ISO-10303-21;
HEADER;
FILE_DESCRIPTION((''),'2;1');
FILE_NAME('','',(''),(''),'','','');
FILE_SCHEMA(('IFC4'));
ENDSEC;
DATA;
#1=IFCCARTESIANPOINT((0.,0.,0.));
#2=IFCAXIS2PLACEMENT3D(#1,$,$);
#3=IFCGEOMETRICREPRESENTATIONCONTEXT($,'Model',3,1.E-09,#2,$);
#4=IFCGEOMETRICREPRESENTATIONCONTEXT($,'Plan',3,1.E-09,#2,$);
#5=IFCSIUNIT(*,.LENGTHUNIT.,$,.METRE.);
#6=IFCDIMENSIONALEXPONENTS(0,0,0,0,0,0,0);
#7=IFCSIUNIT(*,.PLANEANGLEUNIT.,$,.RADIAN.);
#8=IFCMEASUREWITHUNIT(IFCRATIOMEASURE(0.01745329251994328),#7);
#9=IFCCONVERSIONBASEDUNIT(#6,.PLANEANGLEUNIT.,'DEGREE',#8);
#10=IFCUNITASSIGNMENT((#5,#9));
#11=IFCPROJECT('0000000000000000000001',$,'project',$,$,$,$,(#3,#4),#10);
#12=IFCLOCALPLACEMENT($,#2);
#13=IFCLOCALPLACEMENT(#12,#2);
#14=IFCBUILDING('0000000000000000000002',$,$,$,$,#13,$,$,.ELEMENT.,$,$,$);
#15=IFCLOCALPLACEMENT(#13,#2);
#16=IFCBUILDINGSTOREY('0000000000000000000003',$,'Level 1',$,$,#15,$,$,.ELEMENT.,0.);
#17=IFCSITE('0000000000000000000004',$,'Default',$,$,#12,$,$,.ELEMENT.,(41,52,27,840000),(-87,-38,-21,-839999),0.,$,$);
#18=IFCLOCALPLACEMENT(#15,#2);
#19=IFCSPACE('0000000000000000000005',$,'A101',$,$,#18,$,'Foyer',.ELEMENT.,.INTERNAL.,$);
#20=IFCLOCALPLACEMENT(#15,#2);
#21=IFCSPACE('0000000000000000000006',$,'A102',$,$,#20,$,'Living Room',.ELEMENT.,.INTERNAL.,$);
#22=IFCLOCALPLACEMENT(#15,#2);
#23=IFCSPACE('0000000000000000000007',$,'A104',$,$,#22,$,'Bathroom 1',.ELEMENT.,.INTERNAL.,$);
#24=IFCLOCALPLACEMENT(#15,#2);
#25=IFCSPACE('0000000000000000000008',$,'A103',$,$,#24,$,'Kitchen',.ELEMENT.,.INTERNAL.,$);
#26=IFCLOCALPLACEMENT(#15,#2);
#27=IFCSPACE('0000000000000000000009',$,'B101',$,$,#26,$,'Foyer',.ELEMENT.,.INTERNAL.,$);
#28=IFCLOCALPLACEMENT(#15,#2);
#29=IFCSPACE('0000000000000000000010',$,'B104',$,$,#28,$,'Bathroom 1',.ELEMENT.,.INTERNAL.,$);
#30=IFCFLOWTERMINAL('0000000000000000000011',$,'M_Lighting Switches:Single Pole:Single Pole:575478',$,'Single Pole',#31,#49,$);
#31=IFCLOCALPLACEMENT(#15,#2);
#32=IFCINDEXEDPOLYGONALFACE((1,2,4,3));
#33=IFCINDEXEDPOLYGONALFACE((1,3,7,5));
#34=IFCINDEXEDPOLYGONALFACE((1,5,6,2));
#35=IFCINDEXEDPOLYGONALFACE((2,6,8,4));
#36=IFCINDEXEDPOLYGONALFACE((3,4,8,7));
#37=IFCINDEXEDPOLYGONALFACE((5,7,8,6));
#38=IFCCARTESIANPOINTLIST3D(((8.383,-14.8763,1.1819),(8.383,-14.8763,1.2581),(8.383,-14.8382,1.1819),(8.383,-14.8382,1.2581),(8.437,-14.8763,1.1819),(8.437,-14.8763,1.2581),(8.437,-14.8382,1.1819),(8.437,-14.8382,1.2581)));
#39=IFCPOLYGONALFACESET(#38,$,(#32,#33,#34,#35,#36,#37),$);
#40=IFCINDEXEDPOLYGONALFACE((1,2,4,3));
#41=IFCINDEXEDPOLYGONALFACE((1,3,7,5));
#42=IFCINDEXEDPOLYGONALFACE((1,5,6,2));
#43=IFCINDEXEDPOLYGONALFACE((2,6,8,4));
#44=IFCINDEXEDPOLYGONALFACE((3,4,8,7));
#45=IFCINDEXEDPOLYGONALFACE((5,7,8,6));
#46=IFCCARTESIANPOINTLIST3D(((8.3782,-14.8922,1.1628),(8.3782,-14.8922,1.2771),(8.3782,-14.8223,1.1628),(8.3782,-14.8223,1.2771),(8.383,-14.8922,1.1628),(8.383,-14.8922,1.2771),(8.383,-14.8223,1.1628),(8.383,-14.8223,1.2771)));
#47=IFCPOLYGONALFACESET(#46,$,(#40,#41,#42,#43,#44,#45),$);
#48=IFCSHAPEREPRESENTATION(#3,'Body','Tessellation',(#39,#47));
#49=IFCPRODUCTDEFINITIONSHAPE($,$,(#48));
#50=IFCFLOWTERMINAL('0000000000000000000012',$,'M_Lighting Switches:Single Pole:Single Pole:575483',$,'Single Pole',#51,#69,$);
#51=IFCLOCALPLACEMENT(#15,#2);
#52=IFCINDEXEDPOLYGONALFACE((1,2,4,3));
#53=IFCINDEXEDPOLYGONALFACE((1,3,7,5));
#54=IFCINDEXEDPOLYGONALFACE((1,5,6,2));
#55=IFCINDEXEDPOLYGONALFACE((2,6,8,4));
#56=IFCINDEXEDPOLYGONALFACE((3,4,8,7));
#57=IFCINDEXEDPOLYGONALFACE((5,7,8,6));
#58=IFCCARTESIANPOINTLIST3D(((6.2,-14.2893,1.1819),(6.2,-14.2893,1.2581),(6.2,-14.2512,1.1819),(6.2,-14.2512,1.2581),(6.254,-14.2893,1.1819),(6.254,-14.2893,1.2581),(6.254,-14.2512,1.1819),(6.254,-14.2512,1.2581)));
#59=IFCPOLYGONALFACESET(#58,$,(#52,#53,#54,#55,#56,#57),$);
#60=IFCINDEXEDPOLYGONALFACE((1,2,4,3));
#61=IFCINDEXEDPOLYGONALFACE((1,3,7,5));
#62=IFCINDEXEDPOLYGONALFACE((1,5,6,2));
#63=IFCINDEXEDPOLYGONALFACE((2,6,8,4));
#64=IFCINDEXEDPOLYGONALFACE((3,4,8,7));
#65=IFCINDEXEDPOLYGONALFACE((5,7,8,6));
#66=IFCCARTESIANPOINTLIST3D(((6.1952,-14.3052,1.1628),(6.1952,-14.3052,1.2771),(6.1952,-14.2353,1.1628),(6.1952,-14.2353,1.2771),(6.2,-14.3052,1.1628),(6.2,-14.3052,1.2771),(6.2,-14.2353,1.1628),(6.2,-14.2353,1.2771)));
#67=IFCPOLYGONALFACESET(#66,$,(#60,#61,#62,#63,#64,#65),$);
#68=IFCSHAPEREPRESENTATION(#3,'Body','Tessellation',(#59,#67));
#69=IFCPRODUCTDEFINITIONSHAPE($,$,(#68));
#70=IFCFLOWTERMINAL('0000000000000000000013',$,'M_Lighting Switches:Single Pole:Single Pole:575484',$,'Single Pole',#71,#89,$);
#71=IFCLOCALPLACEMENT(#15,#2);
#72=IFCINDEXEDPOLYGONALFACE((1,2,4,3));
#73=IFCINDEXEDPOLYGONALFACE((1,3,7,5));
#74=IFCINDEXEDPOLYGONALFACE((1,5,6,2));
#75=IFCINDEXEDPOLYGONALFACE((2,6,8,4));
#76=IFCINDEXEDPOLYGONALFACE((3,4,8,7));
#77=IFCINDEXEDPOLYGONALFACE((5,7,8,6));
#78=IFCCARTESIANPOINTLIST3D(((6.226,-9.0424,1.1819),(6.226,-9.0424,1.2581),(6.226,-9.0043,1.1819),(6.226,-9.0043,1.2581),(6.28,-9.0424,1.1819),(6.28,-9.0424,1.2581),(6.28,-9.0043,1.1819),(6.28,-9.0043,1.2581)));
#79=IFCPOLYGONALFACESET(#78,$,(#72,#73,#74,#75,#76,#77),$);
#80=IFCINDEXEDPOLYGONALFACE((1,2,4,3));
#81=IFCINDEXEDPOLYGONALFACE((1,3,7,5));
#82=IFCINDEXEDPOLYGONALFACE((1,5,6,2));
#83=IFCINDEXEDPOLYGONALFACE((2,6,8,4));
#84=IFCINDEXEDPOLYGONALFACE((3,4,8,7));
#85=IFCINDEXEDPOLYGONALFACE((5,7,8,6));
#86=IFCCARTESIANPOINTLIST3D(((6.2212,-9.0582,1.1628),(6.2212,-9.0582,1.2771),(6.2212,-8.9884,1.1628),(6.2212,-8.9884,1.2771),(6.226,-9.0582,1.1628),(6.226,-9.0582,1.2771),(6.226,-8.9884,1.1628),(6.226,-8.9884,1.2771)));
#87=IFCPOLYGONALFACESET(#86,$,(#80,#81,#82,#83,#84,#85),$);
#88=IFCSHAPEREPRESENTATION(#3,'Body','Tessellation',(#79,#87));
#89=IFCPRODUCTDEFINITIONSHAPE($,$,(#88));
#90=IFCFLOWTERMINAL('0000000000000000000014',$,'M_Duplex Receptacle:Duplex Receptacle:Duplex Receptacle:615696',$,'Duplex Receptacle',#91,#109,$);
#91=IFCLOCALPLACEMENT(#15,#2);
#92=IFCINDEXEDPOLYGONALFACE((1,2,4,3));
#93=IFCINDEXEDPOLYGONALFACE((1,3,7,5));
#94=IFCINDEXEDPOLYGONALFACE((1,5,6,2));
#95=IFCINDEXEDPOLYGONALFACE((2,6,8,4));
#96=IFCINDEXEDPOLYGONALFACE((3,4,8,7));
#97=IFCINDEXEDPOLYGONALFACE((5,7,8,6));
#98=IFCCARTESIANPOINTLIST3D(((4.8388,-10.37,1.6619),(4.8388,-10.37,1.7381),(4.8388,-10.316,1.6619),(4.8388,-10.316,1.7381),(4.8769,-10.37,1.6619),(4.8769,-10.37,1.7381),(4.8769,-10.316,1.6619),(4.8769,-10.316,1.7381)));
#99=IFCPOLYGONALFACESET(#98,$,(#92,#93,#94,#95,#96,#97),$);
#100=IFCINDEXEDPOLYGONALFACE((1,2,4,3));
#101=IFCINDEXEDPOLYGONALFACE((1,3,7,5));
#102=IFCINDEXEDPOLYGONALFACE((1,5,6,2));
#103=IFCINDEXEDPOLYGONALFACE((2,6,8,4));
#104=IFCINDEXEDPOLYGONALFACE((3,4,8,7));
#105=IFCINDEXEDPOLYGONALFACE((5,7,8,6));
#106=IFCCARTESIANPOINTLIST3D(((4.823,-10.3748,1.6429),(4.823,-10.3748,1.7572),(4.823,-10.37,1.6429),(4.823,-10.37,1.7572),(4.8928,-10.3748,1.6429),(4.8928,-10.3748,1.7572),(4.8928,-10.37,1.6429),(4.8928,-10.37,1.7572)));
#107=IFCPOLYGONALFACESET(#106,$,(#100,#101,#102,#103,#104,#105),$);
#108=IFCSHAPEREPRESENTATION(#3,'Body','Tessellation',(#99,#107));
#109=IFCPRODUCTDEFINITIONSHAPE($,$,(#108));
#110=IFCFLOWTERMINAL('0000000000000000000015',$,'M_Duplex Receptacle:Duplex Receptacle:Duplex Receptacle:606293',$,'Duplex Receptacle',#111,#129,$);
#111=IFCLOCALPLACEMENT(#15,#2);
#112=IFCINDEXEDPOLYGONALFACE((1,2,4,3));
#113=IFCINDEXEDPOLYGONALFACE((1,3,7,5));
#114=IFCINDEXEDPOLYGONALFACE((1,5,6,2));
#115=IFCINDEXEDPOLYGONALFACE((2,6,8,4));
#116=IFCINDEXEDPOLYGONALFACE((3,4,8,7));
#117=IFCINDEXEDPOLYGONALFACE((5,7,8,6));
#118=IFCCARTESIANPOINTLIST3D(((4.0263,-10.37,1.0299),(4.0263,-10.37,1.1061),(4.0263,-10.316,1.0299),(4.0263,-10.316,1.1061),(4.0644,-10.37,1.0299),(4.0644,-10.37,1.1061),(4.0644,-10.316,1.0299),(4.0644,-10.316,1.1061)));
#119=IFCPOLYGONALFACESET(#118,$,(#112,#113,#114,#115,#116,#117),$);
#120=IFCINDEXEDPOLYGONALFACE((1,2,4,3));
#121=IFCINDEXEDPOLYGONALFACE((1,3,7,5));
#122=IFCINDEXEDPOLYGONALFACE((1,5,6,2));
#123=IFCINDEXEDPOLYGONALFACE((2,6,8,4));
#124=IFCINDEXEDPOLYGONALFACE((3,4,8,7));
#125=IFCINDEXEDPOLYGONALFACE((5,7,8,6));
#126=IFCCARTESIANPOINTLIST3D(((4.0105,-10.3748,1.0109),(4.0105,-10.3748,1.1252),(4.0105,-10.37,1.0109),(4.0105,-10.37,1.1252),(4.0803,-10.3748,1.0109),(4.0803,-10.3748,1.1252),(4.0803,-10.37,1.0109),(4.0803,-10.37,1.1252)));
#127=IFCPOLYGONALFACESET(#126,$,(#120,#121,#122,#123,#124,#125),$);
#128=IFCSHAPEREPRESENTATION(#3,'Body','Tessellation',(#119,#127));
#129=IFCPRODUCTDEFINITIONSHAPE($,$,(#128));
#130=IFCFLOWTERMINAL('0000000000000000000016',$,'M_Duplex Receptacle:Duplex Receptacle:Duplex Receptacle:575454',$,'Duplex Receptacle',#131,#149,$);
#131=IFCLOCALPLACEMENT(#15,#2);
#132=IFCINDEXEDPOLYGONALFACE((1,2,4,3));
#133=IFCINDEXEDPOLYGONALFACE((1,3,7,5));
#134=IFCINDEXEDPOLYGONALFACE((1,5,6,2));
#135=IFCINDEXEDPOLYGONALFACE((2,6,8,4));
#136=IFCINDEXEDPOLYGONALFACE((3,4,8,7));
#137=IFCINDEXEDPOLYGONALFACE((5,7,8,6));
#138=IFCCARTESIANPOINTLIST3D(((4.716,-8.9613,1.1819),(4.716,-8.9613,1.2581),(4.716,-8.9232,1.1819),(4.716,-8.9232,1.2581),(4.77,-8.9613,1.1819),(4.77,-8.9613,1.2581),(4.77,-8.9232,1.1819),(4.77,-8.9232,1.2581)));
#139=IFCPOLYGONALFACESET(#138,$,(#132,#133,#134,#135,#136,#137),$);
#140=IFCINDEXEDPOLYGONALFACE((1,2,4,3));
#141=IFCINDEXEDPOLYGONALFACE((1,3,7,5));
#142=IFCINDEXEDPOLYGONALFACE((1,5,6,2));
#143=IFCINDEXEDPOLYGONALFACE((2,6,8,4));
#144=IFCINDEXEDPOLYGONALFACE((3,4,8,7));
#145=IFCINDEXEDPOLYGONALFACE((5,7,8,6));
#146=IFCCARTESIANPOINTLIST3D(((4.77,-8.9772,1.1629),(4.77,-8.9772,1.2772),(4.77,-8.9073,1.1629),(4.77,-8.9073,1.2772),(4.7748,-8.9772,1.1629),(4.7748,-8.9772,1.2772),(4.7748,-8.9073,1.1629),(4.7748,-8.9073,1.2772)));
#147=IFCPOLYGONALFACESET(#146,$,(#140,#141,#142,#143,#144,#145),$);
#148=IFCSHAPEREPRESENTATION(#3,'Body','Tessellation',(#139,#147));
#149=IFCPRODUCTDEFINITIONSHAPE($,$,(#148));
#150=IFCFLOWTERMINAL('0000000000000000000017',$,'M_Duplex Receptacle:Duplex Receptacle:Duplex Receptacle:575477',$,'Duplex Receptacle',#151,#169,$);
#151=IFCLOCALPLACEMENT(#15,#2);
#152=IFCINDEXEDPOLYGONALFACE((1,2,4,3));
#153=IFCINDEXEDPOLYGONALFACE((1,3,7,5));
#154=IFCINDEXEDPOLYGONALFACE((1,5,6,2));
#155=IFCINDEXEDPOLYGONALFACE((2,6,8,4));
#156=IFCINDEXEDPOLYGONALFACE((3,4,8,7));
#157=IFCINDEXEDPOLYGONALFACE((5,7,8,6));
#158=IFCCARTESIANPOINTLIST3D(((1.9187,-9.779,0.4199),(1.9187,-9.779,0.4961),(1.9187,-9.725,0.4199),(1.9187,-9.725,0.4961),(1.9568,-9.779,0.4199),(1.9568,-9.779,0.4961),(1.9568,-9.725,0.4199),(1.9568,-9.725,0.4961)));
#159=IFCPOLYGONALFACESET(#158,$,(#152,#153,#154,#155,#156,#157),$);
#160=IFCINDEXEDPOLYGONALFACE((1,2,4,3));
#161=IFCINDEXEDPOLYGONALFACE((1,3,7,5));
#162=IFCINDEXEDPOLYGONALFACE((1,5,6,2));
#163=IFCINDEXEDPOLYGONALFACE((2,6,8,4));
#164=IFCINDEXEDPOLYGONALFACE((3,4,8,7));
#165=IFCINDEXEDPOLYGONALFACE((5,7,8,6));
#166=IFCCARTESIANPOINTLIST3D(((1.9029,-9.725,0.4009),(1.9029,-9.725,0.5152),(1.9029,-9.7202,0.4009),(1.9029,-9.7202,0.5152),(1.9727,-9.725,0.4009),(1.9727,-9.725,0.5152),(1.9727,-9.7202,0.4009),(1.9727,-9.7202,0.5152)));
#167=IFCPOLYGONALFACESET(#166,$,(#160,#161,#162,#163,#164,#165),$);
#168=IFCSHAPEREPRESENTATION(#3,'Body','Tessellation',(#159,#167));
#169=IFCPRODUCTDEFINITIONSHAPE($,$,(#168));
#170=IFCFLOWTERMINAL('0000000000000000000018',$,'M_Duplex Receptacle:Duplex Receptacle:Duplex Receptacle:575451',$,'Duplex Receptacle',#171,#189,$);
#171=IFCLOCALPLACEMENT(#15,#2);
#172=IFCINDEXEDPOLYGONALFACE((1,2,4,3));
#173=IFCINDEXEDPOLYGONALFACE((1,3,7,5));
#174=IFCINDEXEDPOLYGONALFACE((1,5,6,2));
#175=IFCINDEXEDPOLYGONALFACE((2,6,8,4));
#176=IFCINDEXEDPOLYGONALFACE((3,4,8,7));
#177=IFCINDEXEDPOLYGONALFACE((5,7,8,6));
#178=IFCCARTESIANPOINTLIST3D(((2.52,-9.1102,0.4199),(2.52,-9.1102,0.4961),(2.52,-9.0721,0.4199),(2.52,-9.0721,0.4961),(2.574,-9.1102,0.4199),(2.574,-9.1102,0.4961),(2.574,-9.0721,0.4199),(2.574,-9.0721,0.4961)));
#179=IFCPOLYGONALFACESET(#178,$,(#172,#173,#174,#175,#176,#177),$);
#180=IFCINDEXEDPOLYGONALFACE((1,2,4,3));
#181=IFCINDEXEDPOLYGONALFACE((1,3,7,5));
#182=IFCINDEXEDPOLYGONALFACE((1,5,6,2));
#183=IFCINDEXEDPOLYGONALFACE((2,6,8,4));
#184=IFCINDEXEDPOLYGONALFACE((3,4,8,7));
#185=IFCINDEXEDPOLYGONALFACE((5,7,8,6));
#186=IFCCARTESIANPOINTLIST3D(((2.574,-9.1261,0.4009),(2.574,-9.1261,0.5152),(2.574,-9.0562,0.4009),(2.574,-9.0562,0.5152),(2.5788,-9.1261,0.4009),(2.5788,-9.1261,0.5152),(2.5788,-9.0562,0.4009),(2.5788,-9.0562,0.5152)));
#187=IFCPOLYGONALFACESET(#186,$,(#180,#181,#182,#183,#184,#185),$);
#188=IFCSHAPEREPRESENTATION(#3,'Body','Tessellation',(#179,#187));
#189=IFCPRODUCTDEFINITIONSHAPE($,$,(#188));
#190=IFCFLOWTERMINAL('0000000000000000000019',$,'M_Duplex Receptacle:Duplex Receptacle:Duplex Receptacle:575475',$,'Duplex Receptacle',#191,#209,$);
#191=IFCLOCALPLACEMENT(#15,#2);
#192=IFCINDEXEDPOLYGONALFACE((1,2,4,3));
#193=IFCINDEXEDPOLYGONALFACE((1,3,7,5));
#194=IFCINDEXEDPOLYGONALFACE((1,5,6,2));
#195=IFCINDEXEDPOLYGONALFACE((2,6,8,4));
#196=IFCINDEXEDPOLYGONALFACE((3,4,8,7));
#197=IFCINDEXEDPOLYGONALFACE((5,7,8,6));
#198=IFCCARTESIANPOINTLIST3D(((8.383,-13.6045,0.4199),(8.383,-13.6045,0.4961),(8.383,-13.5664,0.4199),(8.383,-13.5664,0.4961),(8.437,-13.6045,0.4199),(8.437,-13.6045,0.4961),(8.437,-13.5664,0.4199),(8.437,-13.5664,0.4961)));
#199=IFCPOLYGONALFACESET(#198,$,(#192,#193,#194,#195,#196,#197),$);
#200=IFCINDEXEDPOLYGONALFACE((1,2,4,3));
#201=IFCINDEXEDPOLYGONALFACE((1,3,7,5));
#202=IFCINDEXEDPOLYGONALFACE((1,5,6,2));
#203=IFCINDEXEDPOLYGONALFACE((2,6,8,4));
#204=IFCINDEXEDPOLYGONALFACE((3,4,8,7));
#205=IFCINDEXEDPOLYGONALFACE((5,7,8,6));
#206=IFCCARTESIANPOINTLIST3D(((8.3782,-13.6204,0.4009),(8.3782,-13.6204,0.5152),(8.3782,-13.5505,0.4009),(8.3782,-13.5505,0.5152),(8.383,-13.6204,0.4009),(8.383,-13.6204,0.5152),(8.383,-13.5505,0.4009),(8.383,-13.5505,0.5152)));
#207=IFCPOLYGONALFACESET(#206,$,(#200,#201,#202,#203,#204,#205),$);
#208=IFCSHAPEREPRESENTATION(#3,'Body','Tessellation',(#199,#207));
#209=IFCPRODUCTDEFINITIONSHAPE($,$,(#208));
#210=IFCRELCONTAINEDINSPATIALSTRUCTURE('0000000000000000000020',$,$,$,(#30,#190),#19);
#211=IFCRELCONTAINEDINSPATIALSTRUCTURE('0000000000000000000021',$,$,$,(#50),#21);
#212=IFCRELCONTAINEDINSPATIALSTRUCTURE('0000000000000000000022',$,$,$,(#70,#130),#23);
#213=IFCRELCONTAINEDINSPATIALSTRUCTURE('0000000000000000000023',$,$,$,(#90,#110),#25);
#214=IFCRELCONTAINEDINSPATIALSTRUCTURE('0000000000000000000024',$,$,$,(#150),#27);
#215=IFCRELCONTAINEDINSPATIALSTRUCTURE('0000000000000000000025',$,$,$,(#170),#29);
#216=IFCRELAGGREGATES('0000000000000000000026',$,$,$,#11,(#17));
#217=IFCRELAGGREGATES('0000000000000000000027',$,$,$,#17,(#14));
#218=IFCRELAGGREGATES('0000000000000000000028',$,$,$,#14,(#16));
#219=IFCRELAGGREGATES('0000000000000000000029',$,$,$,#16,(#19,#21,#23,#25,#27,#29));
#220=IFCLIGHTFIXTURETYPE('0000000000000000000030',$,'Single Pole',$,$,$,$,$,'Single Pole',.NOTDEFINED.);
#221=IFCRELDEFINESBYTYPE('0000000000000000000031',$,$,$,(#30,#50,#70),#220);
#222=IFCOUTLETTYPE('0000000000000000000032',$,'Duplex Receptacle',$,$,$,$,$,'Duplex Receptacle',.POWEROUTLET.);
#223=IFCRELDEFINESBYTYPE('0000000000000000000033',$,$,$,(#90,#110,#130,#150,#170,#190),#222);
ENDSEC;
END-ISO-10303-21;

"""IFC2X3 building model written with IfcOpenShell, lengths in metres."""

from ifc_helpers import new_model, entity, si_unit, converted_unit, frame, origin, origin_2d_with_axis, place, context, project, spatial, rectangle, extrude, source, transform, mapped, type_object, type_shapes, element, save


model = new_model("IFC2X3")

# Units and contexts
model_context = context("Model", 3, precision=1e-09, world=origin())
plan_context = context("Plan", 3, precision=1e-09, world=origin())
ifc_project = project(units=[si_unit("LENGTHUNIT", "METRE"), converted_unit("PLANEANGLEUNIT", "DEGREE", entity("IfcRatioMeasure", 0.01745329251994328), si_unit("PLANEANGLEUNIT", "RADIAN"), dimensions=[0, 0, 0, 0, 0, 0, 0])], contexts=[model_context, plan_context])

# Site, building, storey, space
site_placement = place(None, origin())
site = spatial("IfcSite", under=ifc_project, at=site_placement, Name="Default", CompositionType="ELEMENT", RefLatitude=(41, 52, 27, 840000), RefLongitude=(-87, -38, -21, -839999), RefElevation=0.0)
building_placement = place(site_placement, origin())
building = spatial("IfcBuilding", under=site, at=building_placement, CompositionType="ELEMENT")
storey_placement = place(building_placement, origin())
storey = spatial("IfcBuildingStorey", under=building, at=storey_placement, Name="Level 1", CompositionType="ELEMENT", Elevation=0.0)
space_1_placement = place(storey_placement, origin())
space_1 = spatial("IfcSpace", under=storey, at=space_1_placement, Name="A101", LongName="Foyer", CompositionType="ELEMENT", InteriorOrExteriorSpace="INTERNAL")

# Flow terminal
light_fixture_type = type_object("IfcLightFixtureType", Name="Single Pole", ElementType="Single Pole", PredefinedType="NOTDEFINED")
shared_shape_1 = source(origin(), model_context, "Body", "SweptSolid", [
    extrude(rectangle(XDim=0.0381, YDim=0.0762, at=origin_2d_with_axis()), frame((0.0, 0.0, -0.054), z_axis=(0.0, 0.0, 1.0), x_axis=(-1.0, 0.0, 0.0)), (0.0, 0.0, 1.0), 0.054),
    extrude(rectangle(XDim=0.0698, YDim=0.1143, at=origin_2d_with_axis()), frame((0.0, 0.0, 0.0), z_axis=(0.0, 0.0, 1.0), x_axis=(-1.0, 0.0, 0.0)), (0.0, 0.0, 1.0), 0.0048),
])
type_shapes(light_fixture_type, [shared_shape_1])
flow_terminal_1_placement = place(space_1_placement, frame((8.383, -14.8573, 1.22), z_axis=(-1.0, 0.0, 0.0), x_axis=(0.0, -1.0, 0.0)))
element("IfcFlowTerminal", 1, at=flow_terminal_1_placement, inside=space_1, type_object=light_fixture_type, Name="M_Lighting Switches:Single Pole:Single Pole:575478", ObjectType="Single Pole", context=model_context, shape_type="MappedRepresentation", body=[
    mapped(shared_shape_1, transform((0.0, 0.0, 0.0), scale=1.0)),
])

# Shared definitions
space_2_placement = place(storey_placement, origin())
space_2 = spatial("IfcSpace", under=storey, at=space_2_placement, Name="A102", LongName="Living Room", CompositionType="ELEMENT", InteriorOrExteriorSpace="INTERNAL")

# Flow terminal
flow_terminal_2_placement = place(space_2_placement, frame((6.2, -14.2702, 1.22), z_axis=(-1.0, 0.0, 0.0), x_axis=(0.0, -1.0, 0.0)))
element("IfcFlowTerminal", 2, at=flow_terminal_2_placement, inside=space_2, type_object=light_fixture_type, Name="M_Lighting Switches:Single Pole:Single Pole:575483", ObjectType="Single Pole", context=model_context, shape_type="MappedRepresentation", body=[
    mapped(shared_shape_1, transform((0.0, 0.0, 0.0), scale=1.0)),
])

# Shared definitions
space_3_placement = place(storey_placement, origin())
space_3 = spatial("IfcSpace", under=storey, at=space_3_placement, Name="A104", LongName="Bathroom 1", CompositionType="ELEMENT", InteriorOrExteriorSpace="INTERNAL")

# Flow terminal
flow_terminal_3_placement = place(space_3_placement, frame((6.226, -9.0233, 1.22), z_axis=(-1.0, 0.0, 0.0), x_axis=(0.0, -1.0, 0.0)))
element("IfcFlowTerminal", 3, at=flow_terminal_3_placement, inside=space_3, type_object=light_fixture_type, Name="M_Lighting Switches:Single Pole:Single Pole:575484", ObjectType="Single Pole", context=model_context, shape_type="MappedRepresentation", body=[
    mapped(shared_shape_1, transform((0.0, 0.0, 0.0), scale=1.0)),
])

# Shared definitions
space_4_placement = place(storey_placement, origin())
space_4 = spatial("IfcSpace", under=storey, at=space_4_placement, Name="A103", LongName="Kitchen", CompositionType="ELEMENT", InteriorOrExteriorSpace="INTERNAL")

# Flow terminals
outlet_type = type_object("IfcOutletType", Name="Duplex Receptacle", ElementType="Duplex Receptacle", PredefinedType="POWEROUTLET")
type_shapes(outlet_type, [shared_shape_1])
for number, where, z_axis, x_axis, name in (
    (4, (4.8579, -10.37, 1.7), (0.0, -1.0, 0.0), (1.0, 0.0, 0.0), "M_Duplex Receptacle:Duplex Receptacle:Duplex Receptacle:615696"),
    (5, (4.0454, -10.37, 1.068), (0.0, -1.0, 0.0), (1.0, 0.0, 0.0), "M_Duplex Receptacle:Duplex Receptacle:Duplex Receptacle:606293"),
):
    element("IfcFlowTerminal", number, at=place(space_4_placement, frame(where, z_axis=z_axis, x_axis=x_axis)), inside=space_4, type_object=outlet_type, Name=name, ObjectType="Duplex Receptacle", context=model_context, shape_type="MappedRepresentation", body=[
        mapped(shared_shape_1, transform((0.0, 0.0, 0.0), scale=1.0)),
    ])
flow_terminal_4_placement = place(space_3_placement, frame((4.77, -8.9422, 1.22), z_axis=(1.0, 0.0, 0.0), x_axis=(0.0, 1.0, 0.0)))
element("IfcFlowTerminal", 6, at=flow_terminal_4_placement, inside=space_3, type_object=outlet_type, Name="M_Duplex Receptacle:Duplex Receptacle:Duplex Receptacle:575454", ObjectType="Duplex Receptacle", context=model_context, shape_type="MappedRepresentation", body=[
    mapped(shared_shape_1, transform((0.0, 0.0, 0.0), scale=1.0)),
])

# Shared definitions
space_5_placement = place(storey_placement, origin())
space_5 = spatial("IfcSpace", under=storey, at=space_5_placement, Name="B101", LongName="Foyer", CompositionType="ELEMENT", InteriorOrExteriorSpace="INTERNAL")

# Flow terminal
flow_terminal_5_placement = place(space_5_placement, frame((1.9378, -9.725, 0.458), z_axis=(0.0, 1.0, 0.0), x_axis=(-1.0, 0.0, 0.0)))
element("IfcFlowTerminal", 7, at=flow_terminal_5_placement, inside=space_5, type_object=outlet_type, Name="M_Duplex Receptacle:Duplex Receptacle:Duplex Receptacle:575477", ObjectType="Duplex Receptacle", context=model_context, shape_type="MappedRepresentation", body=[
    mapped(shared_shape_1, transform((0.0, 0.0, 0.0), scale=1.0)),
])

# Shared definitions
space_6_placement = place(storey_placement, origin())
space_6 = spatial("IfcSpace", under=storey, at=space_6_placement, Name="B104", LongName="Bathroom 1", CompositionType="ELEMENT", InteriorOrExteriorSpace="INTERNAL")

# Flow terminals
flow_terminal_6_placement = place(space_6_placement, frame((2.574, -9.0912, 0.458), z_axis=(1.0, 0.0, 0.0), x_axis=(0.0, 1.0, 0.0)))
element("IfcFlowTerminal", 8, at=flow_terminal_6_placement, inside=space_6, type_object=outlet_type, Name="M_Duplex Receptacle:Duplex Receptacle:Duplex Receptacle:575451", ObjectType="Duplex Receptacle", context=model_context, shape_type="MappedRepresentation", body=[
    mapped(shared_shape_1, transform((0.0, 0.0, 0.0), scale=1.0)),
])
flow_terminal_7_placement = place(space_1_placement, frame((8.383, -13.5854, 0.458), z_axis=(-1.0, 0.0, 0.0), x_axis=(0.0, -1.0, 0.0)))
element("IfcFlowTerminal", 9, at=flow_terminal_7_placement, inside=space_1, type_object=outlet_type, Name="M_Duplex Receptacle:Duplex Receptacle:Duplex Receptacle:575475", ObjectType="Duplex Receptacle", context=model_context, shape_type="MappedRepresentation", body=[
    mapped(shared_shape_1, transform((0.0, 0.0, 0.0), scale=1.0)),
])

save(model, "model.ifc")
